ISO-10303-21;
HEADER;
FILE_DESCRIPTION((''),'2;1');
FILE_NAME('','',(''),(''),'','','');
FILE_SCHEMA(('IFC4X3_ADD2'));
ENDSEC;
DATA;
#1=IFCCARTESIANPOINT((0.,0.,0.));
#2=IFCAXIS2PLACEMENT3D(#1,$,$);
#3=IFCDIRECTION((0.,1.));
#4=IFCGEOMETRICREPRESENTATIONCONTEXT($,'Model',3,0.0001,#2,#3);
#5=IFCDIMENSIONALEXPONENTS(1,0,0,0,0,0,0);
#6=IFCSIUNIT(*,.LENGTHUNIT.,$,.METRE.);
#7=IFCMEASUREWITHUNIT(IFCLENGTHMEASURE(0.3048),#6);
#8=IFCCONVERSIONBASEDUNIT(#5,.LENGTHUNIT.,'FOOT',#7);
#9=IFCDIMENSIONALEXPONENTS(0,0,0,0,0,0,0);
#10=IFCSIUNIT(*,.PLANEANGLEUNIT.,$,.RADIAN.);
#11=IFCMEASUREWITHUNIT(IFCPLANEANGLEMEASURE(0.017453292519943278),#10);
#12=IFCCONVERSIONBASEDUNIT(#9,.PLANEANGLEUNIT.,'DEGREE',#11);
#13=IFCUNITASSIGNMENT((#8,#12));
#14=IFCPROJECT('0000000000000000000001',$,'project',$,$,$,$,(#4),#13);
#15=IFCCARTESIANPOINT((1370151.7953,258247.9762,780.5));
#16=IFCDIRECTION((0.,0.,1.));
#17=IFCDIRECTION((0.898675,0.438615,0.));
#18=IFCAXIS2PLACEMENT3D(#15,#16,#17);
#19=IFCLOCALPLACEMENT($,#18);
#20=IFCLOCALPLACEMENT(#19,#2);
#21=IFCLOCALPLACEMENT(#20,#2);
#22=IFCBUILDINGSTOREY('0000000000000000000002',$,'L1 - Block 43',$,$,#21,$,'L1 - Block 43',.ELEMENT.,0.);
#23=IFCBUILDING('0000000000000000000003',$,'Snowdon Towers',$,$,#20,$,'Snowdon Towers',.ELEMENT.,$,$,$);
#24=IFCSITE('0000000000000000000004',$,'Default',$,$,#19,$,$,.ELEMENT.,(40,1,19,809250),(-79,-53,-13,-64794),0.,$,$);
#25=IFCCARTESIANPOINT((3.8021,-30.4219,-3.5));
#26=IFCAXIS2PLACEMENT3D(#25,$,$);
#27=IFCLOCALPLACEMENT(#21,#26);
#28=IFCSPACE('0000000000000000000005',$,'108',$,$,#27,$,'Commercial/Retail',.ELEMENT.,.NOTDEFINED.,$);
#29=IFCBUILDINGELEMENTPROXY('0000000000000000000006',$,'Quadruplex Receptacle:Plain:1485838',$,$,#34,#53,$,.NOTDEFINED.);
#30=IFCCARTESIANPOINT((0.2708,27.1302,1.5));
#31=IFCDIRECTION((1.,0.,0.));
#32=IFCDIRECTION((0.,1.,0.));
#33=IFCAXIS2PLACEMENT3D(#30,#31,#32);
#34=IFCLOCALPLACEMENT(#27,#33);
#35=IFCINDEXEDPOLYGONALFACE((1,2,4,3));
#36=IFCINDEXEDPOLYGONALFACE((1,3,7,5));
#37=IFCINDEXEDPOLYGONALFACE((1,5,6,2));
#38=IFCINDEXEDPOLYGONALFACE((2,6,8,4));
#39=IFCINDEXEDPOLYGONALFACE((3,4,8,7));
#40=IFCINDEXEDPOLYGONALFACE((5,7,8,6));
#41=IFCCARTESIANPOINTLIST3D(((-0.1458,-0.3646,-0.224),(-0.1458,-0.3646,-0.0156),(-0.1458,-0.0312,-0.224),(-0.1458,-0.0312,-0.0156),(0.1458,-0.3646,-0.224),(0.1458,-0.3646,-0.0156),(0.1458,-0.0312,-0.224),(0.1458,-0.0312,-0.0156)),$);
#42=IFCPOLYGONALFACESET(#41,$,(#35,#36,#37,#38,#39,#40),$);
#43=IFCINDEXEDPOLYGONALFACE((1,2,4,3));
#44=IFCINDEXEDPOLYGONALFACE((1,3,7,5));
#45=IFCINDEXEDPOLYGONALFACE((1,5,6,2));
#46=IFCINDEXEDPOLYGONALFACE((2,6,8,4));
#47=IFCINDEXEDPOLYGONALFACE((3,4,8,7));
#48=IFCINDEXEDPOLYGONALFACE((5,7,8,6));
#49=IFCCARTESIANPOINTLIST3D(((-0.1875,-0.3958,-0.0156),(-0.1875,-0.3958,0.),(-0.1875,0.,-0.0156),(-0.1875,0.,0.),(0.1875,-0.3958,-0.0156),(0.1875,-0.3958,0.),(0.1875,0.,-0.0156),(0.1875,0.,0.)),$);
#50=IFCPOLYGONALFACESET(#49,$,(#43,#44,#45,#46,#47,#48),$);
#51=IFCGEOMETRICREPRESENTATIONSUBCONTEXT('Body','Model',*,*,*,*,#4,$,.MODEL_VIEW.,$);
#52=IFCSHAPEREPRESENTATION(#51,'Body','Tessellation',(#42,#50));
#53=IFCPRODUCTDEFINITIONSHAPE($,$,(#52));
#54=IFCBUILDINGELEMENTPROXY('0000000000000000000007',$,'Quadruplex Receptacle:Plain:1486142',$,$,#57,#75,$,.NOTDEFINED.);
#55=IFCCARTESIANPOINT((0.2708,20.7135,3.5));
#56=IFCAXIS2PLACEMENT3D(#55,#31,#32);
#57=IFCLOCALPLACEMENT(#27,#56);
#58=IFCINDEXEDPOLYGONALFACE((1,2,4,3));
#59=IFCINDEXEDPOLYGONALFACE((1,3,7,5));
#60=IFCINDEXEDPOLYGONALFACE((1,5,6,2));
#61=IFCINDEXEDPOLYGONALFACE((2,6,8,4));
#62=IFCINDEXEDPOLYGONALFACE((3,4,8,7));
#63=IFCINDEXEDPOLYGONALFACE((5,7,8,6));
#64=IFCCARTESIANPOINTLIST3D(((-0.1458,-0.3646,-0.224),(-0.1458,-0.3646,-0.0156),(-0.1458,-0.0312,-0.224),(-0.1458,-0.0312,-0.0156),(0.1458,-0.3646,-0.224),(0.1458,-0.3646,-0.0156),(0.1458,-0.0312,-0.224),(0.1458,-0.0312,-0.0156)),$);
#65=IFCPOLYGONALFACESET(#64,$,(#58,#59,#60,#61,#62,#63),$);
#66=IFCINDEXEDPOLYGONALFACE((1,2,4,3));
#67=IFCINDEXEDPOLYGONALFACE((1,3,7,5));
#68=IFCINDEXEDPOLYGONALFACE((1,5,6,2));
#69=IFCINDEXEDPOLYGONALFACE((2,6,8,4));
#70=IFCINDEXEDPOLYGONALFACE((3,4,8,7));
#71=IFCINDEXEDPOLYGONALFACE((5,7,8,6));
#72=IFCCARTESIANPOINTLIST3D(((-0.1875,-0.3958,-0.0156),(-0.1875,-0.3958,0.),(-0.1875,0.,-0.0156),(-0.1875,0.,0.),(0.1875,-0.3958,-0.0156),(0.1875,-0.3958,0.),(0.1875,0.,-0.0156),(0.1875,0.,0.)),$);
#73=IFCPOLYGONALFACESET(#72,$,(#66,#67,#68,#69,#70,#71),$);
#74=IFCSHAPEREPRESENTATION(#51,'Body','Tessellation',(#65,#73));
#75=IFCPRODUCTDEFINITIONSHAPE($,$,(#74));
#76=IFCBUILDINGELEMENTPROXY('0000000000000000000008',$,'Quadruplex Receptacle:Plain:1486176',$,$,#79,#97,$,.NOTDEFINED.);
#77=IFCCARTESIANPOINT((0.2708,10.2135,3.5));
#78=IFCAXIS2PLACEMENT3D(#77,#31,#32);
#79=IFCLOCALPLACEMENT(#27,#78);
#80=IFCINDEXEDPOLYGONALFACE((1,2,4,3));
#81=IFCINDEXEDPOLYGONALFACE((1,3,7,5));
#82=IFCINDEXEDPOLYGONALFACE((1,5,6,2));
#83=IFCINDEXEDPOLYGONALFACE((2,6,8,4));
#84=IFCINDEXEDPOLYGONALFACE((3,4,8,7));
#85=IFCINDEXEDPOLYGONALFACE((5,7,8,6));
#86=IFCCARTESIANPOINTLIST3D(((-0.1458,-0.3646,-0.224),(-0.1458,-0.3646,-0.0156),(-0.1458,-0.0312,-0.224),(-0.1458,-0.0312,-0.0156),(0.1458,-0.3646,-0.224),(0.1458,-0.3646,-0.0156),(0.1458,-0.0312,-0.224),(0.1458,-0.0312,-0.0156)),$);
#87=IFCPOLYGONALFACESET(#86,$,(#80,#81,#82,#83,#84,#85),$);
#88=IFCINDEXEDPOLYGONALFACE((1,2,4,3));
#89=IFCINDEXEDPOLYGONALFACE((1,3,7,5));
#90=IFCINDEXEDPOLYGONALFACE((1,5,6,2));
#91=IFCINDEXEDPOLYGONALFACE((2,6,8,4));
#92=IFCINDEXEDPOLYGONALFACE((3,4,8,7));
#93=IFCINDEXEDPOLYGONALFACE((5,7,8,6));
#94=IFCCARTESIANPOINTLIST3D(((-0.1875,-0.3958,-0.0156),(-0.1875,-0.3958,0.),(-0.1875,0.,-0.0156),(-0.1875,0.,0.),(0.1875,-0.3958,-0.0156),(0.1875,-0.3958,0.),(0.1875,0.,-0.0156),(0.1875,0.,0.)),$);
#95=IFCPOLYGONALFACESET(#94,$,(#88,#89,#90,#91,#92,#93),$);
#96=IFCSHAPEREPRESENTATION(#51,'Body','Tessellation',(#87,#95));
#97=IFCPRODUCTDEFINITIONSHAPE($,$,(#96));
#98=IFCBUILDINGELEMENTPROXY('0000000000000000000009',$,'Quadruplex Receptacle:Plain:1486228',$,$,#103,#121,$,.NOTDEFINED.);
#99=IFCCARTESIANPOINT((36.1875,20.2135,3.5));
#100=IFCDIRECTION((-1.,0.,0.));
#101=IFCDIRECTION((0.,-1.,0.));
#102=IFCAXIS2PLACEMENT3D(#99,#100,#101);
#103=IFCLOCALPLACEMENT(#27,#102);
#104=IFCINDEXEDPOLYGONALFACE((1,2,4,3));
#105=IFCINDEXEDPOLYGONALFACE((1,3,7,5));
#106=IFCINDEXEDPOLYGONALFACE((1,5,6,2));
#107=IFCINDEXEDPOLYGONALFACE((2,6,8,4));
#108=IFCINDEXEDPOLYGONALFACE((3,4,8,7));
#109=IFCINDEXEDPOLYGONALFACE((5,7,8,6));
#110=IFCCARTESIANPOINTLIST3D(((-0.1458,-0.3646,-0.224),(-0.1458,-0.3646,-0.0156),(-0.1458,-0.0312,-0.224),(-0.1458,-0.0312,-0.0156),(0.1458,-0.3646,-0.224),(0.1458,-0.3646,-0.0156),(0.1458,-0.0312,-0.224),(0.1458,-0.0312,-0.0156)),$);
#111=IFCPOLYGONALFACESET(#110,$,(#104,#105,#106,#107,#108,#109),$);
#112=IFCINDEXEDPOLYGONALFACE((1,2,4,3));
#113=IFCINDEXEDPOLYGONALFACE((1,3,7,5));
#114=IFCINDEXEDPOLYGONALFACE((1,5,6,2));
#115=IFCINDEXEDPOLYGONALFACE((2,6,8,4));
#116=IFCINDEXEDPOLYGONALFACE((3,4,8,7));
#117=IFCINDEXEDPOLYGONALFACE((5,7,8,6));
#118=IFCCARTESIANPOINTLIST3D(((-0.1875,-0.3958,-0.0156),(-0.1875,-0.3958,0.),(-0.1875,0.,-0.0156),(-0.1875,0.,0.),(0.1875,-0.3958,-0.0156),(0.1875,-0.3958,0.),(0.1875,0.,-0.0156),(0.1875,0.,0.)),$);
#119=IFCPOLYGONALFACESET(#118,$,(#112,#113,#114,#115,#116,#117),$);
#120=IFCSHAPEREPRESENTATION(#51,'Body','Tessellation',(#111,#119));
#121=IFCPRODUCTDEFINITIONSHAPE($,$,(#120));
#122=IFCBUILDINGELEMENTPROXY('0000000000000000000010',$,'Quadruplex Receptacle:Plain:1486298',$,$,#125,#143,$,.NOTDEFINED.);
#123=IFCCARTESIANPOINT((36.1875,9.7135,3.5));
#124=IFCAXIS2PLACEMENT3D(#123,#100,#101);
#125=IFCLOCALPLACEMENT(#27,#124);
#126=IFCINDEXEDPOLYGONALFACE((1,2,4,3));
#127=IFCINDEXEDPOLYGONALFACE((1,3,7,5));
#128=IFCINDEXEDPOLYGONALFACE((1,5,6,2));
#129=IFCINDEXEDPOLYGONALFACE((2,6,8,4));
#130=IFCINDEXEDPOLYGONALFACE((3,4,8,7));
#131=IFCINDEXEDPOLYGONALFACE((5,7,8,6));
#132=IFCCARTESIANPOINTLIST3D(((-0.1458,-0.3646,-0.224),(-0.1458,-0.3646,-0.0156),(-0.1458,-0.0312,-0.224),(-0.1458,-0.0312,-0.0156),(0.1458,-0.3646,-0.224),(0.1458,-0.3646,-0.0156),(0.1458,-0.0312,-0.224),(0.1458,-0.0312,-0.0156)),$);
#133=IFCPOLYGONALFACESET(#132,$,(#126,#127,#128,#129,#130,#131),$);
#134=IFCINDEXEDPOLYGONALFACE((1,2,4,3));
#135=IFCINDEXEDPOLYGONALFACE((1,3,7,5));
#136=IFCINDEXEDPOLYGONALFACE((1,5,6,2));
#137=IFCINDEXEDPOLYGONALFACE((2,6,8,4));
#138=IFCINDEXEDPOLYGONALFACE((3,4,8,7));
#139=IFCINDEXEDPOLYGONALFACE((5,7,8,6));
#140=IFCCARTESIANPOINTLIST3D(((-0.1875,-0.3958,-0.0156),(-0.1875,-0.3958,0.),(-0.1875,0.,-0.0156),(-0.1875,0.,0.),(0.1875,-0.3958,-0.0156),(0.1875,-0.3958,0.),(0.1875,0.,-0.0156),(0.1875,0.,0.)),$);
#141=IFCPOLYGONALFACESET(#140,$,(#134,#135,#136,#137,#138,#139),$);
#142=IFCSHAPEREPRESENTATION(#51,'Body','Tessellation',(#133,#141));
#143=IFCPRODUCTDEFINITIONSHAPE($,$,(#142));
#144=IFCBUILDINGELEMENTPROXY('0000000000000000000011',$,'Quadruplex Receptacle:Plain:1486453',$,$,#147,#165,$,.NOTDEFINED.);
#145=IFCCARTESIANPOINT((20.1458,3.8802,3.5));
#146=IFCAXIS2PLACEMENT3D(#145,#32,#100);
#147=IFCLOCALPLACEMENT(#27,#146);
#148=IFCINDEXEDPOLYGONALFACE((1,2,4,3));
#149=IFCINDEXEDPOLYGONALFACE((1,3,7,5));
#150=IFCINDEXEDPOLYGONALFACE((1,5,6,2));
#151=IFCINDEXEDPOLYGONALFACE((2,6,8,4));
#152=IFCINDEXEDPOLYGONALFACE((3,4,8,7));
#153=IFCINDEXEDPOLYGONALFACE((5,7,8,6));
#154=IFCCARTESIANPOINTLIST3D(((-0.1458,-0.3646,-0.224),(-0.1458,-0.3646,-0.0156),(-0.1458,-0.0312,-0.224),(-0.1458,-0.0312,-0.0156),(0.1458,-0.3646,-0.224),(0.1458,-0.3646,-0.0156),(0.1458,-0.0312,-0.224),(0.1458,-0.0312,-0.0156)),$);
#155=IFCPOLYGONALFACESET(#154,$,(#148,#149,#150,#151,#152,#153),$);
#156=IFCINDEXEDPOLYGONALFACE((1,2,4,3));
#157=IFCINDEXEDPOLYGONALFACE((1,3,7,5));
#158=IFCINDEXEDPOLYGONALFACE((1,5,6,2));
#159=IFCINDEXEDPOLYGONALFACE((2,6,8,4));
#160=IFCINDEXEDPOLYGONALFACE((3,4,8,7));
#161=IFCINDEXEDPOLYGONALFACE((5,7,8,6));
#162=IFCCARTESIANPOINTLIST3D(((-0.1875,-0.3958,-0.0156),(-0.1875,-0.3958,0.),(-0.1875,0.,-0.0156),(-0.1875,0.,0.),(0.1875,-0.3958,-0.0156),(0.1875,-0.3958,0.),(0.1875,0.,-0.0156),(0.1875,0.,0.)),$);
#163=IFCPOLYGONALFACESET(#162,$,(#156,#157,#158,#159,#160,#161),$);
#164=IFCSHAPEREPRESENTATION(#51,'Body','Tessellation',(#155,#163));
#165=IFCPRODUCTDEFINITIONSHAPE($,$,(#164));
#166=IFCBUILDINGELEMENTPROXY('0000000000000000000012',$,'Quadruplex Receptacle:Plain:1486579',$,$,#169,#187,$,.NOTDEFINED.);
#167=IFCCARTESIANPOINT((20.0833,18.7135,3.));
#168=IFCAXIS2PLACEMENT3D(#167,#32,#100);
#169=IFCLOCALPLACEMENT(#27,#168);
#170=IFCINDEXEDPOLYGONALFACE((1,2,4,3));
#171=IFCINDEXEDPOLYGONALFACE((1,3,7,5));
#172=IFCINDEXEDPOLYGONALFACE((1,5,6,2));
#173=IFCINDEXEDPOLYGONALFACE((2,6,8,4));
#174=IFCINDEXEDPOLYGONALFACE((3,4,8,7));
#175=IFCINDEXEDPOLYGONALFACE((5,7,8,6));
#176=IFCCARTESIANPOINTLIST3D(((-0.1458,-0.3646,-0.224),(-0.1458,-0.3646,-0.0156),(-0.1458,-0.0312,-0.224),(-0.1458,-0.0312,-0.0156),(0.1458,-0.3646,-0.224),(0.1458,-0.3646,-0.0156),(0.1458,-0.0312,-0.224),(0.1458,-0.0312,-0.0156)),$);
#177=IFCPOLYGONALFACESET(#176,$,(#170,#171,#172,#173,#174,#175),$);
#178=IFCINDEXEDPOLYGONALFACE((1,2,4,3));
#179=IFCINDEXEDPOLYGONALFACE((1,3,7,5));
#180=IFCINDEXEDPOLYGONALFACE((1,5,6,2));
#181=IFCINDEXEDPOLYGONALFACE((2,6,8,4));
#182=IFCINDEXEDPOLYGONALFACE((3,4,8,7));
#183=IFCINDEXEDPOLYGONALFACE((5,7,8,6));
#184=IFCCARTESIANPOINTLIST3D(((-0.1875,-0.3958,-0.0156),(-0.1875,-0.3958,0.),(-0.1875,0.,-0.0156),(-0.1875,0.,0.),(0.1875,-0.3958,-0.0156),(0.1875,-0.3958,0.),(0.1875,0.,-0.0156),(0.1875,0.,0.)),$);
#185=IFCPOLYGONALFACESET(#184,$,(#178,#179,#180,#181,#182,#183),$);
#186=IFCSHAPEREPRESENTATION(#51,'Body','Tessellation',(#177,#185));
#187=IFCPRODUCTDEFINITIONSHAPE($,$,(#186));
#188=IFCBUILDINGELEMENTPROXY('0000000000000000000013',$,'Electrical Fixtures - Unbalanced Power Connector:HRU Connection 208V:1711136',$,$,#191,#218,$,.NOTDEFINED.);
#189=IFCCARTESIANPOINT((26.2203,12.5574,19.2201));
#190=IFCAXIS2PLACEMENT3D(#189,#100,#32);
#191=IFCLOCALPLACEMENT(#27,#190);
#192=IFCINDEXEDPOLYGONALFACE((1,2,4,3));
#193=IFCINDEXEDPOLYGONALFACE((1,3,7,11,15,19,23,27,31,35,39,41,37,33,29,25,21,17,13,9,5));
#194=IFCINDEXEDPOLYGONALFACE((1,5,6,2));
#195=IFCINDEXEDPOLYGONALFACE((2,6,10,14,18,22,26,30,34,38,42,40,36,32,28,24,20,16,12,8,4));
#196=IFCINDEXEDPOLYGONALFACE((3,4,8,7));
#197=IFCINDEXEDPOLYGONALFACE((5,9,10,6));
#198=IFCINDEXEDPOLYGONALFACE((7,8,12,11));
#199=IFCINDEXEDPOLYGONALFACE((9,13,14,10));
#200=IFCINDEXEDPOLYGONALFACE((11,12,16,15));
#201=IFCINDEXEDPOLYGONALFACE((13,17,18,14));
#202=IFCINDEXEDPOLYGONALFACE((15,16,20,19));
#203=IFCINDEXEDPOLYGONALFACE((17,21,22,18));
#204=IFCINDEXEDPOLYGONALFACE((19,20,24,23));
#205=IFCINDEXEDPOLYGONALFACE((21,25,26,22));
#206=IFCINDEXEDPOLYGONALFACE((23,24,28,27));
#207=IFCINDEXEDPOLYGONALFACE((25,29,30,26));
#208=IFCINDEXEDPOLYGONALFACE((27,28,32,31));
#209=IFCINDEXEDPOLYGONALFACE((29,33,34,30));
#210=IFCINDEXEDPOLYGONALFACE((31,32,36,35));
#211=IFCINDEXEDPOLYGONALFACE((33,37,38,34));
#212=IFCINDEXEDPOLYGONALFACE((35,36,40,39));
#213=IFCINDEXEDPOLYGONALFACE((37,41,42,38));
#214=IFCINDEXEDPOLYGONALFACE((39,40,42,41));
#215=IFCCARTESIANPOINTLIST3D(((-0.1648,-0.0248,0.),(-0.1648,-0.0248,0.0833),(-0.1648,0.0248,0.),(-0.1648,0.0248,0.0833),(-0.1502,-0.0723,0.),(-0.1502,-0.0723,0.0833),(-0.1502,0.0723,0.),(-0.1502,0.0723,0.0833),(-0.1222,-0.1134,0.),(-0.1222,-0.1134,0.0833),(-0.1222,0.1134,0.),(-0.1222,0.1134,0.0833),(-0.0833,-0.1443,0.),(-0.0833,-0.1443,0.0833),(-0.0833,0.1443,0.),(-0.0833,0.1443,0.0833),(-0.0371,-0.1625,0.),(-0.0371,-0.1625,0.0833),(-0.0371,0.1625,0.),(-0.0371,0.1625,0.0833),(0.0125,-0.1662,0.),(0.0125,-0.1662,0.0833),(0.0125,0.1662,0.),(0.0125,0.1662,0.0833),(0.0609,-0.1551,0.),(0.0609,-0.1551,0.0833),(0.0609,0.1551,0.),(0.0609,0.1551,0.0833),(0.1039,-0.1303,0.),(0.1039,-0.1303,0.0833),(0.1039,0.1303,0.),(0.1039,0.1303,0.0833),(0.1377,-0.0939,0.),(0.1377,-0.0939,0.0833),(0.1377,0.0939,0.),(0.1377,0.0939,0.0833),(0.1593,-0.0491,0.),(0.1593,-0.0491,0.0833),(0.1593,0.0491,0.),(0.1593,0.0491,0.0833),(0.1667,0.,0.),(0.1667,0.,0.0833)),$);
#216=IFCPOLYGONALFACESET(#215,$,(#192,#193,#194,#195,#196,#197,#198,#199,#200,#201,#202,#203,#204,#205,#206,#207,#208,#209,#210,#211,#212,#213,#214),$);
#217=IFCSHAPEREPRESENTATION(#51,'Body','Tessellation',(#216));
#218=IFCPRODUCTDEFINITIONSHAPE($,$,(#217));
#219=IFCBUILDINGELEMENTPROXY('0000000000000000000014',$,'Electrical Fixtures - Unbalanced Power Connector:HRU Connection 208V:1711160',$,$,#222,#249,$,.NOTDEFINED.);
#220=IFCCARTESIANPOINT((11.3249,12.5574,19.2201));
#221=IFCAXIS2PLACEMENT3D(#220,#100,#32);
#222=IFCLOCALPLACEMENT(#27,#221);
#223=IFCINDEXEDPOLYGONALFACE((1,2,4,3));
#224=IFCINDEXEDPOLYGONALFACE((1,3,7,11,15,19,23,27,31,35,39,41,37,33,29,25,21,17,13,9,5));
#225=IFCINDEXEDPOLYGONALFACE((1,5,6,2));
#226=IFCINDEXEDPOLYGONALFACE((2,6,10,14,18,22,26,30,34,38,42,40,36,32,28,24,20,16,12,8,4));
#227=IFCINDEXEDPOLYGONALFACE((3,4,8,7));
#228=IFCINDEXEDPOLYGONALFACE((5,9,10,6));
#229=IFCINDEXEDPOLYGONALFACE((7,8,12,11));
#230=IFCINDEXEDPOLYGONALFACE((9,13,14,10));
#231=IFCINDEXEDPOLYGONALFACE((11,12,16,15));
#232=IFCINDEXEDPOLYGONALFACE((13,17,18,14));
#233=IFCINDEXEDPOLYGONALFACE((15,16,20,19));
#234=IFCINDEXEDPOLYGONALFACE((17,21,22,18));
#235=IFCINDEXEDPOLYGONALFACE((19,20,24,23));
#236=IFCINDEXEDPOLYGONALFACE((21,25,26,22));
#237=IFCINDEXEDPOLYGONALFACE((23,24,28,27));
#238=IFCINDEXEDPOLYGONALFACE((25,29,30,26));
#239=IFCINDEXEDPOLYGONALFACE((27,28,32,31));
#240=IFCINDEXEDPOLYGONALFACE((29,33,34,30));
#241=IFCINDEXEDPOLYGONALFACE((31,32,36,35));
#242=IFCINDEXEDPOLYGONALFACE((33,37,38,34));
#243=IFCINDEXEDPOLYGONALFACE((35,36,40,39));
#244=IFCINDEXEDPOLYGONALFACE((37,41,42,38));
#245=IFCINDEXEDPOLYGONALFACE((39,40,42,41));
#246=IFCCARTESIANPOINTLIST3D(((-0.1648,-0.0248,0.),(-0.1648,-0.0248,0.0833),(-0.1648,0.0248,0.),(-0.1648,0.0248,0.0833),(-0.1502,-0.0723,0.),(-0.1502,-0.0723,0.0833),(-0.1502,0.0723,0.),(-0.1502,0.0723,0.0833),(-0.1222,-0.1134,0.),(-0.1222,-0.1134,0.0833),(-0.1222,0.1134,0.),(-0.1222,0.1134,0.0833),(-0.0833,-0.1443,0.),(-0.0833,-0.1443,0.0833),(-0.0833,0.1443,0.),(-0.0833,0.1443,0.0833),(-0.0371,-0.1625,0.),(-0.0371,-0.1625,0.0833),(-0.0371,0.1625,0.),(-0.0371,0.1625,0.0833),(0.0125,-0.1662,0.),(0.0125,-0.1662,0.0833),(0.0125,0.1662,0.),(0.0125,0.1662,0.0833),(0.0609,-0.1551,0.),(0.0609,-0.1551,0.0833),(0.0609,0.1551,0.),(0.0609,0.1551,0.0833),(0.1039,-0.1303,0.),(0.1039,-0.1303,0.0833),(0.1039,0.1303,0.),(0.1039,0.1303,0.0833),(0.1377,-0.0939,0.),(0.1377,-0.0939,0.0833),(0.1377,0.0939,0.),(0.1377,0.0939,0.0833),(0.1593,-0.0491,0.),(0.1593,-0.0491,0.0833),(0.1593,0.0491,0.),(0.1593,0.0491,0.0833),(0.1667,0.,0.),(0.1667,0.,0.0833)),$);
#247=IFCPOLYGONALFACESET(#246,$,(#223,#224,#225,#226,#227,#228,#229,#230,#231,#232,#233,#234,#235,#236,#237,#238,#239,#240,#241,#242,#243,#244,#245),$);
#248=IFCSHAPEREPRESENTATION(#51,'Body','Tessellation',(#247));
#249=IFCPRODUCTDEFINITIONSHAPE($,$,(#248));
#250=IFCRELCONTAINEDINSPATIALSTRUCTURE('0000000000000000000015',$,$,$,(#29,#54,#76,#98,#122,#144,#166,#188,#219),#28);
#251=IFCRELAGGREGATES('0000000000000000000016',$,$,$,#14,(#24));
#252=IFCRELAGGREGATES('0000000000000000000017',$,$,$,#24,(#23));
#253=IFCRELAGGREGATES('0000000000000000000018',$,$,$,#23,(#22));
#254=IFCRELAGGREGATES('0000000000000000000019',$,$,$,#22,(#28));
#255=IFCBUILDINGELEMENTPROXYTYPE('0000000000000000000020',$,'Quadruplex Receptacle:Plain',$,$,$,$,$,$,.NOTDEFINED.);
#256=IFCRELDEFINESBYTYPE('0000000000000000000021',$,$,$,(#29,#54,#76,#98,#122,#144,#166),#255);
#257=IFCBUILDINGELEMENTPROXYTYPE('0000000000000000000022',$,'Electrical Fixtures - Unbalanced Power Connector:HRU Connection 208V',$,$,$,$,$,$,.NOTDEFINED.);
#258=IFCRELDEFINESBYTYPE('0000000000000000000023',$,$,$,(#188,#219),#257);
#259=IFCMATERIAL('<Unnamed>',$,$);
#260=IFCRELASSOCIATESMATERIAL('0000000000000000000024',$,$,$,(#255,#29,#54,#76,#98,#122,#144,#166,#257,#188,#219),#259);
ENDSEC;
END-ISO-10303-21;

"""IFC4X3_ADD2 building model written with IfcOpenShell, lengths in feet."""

from ifc_helpers import new_model, entity, si_unit, converted_unit, direction, frame, frame_2d, origin, origin_2d_with_axis, place, context, subcontext, project, spatial, rectangle, circle, extrude, source, transform, mapped, material, type_object, type_shapes, element, save


model = new_model("IFC4X3_ADD2")

# Units and contexts
model_context = context("Model", 3, precision=0.0001, world=origin(), true_north=direction((0.0, 1.0)))
body_context = subcontext(model_context, "Body", "Model", "MODEL_VIEW")
ifc_project = project(units=[converted_unit("LENGTHUNIT", "FOOT", entity("IfcLengthMeasure", 0.3048), si_unit("LENGTHUNIT", "METRE"), dimensions=[1, 0, 0, 0, 0, 0, 0]), converted_unit("PLANEANGLEUNIT", "DEGREE", entity("IfcPlaneAngleMeasure", 0.017453292519943278), si_unit("PLANEANGLEUNIT", "RADIAN"), dimensions=[0, 0, 0, 0, 0, 0, 0])], contexts=[model_context])

# Site, building, storey
site_placement = place(None, frame((1370151.7953, 258247.9762, 780.5), z_axis=(0.0, 0.0, 1.0), x_axis=(0.898675, 0.438615, 0.0)))
site = spatial("IfcSite", under=ifc_project, at=site_placement, Name="Default", CompositionType="ELEMENT", RefLatitude=(40, 1, 19, 809250), RefLongitude=(-79, -53, -13, -64794), RefElevation=0.0)
building_placement = place(site_placement, origin())
building = spatial("IfcBuilding", under=site, at=building_placement, Name="Snowdon Towers", LongName="Snowdon Towers", CompositionType="ELEMENT")
storey_placement = place(building_placement, origin())
storey = spatial("IfcBuildingStorey", under=building, at=storey_placement, Name="L1 - Block 43", LongName="L1 - Block 43", CompositionType="ELEMENT", Elevation=0.0)

# Shared definitions
ifc_material_1 = material(Name="<Unnamed>")

# Shared definitions
space_1_placement = place(storey_placement, frame((3.8021, -30.4219, -3.5)))
space_1 = spatial("IfcSpace", under=storey, at=space_1_placement, Name="108", LongName="Commercial/Retail", CompositionType="ELEMENT", PredefinedType="NOTDEFINED")

# Building element proxies
building_element_proxy_type_1 = type_object("IfcBuildingElementProxyType", Name="Quadruplex Receptacle:Plain", PredefinedType="NOTDEFINED", material=ifc_material_1)
shared_shape_1 = source(origin(), body_context, "Body", "SweptSolid", [
    extrude(rectangle(XDim=0.2917, YDim=0.3333, at=frame_2d((0.0, 0.0), x_axis=(1.0, 0.0))), frame((0.0, -0.1979, -0.224), z_axis=(0.0, 0.0, 1.0), x_axis=(-1.0, 0.0, 0.0)), (0.0, 0.0, 1.0), 0.2083),
    extrude(rectangle(XDim=0.375, YDim=0.3958, at=origin_2d_with_axis()), frame((0.0, -0.1979, -0.0156), z_axis=(0.0, 0.0, 1.0), x_axis=(-1.0, 0.0, 0.0)), (0.0, 0.0, 1.0), 0.0156),
])
type_shapes(building_element_proxy_type_1, [shared_shape_1])
for number, where, z_axis, x_axis, name in (
    (1, (0.2708, 27.1302, 1.5), (1.0, 0.0, 0.0), (0.0, 1.0, 0.0), "Quadruplex Receptacle:Plain:1485838"),
    (2, (0.2708, 20.7135, 3.5), (1.0, 0.0, 0.0), (0.0, 1.0, 0.0), "Quadruplex Receptacle:Plain:1486142"),
    (3, (0.2708, 10.2135, 3.5), (1.0, 0.0, 0.0), (0.0, 1.0, 0.0), "Quadruplex Receptacle:Plain:1486176"),
    (4, (36.1875, 20.2135, 3.5), (-1.0, 0.0, 0.0), (0.0, -1.0, 0.0), "Quadruplex Receptacle:Plain:1486228"),
    (5, (36.1875, 9.7135, 3.5), (-1.0, 0.0, 0.0), (0.0, -1.0, 0.0), "Quadruplex Receptacle:Plain:1486298"),
    (6, (20.1458, 3.8802, 3.5), (0.0, 1.0, 0.0), (-1.0, 0.0, 0.0), "Quadruplex Receptacle:Plain:1486453"),
    (7, (20.0833, 18.7135, 3.0), (0.0, 1.0, 0.0), (-1.0, 0.0, 0.0), "Quadruplex Receptacle:Plain:1486579"),
):
    element("IfcBuildingElementProxy", number, at=place(space_1_placement, frame(where, z_axis=z_axis, x_axis=x_axis)), inside=space_1, type_object=building_element_proxy_type_1, material=ifc_material_1, Name=name, PredefinedType="NOTDEFINED", context=body_context, shape_type="MappedRepresentation", body=[
        mapped(shared_shape_1, transform((0.0, 0.0, 0.0), scale=1.0)),
    ])
building_element_proxy_type_2 = type_object("IfcBuildingElementProxyType", Name="Electrical Fixtures - Unbalanced Power Connector:HRU Connection 208V", PredefinedType="NOTDEFINED", material=ifc_material_1)
shared_shape_2 = source(origin(), body_context, "Body", "SweptSolid", [
    extrude(circle(Radius=0.1667, at=frame_2d((0.0, 0.0), x_axis=(1.0, 0.0))), origin(), (0.0, 0.0, 1.0), 0.0833),
])
type_shapes(building_element_proxy_type_2, [shared_shape_2])
for number, where, z_axis, x_axis, name in (
    (8, (26.2203, 12.5574, 19.2201), (-1.0, 0.0, 0.0), (0.0, 1.0, 0.0), "Electrical Fixtures - Unbalanced Power Connector:HRU Connection 208V:1711136"),
    (9, (11.3249, 12.5574, 19.2201), (-1.0, 0.0, 0.0), (0.0, 1.0, 0.0), "Electrical Fixtures - Unbalanced Power Connector:HRU Connection 208V:1711160"),
):
    element("IfcBuildingElementProxy", number, at=place(space_1_placement, frame(where, z_axis=z_axis, x_axis=x_axis)), inside=space_1, type_object=building_element_proxy_type_2, material=ifc_material_1, Name=name, PredefinedType="NOTDEFINED", context=body_context, shape_type="MappedRepresentation", body=[
        mapped(shared_shape_2, transform((0.0, 0.0, 0.0), scale=1.0)),
    ])

save(model, "model.ifc")
